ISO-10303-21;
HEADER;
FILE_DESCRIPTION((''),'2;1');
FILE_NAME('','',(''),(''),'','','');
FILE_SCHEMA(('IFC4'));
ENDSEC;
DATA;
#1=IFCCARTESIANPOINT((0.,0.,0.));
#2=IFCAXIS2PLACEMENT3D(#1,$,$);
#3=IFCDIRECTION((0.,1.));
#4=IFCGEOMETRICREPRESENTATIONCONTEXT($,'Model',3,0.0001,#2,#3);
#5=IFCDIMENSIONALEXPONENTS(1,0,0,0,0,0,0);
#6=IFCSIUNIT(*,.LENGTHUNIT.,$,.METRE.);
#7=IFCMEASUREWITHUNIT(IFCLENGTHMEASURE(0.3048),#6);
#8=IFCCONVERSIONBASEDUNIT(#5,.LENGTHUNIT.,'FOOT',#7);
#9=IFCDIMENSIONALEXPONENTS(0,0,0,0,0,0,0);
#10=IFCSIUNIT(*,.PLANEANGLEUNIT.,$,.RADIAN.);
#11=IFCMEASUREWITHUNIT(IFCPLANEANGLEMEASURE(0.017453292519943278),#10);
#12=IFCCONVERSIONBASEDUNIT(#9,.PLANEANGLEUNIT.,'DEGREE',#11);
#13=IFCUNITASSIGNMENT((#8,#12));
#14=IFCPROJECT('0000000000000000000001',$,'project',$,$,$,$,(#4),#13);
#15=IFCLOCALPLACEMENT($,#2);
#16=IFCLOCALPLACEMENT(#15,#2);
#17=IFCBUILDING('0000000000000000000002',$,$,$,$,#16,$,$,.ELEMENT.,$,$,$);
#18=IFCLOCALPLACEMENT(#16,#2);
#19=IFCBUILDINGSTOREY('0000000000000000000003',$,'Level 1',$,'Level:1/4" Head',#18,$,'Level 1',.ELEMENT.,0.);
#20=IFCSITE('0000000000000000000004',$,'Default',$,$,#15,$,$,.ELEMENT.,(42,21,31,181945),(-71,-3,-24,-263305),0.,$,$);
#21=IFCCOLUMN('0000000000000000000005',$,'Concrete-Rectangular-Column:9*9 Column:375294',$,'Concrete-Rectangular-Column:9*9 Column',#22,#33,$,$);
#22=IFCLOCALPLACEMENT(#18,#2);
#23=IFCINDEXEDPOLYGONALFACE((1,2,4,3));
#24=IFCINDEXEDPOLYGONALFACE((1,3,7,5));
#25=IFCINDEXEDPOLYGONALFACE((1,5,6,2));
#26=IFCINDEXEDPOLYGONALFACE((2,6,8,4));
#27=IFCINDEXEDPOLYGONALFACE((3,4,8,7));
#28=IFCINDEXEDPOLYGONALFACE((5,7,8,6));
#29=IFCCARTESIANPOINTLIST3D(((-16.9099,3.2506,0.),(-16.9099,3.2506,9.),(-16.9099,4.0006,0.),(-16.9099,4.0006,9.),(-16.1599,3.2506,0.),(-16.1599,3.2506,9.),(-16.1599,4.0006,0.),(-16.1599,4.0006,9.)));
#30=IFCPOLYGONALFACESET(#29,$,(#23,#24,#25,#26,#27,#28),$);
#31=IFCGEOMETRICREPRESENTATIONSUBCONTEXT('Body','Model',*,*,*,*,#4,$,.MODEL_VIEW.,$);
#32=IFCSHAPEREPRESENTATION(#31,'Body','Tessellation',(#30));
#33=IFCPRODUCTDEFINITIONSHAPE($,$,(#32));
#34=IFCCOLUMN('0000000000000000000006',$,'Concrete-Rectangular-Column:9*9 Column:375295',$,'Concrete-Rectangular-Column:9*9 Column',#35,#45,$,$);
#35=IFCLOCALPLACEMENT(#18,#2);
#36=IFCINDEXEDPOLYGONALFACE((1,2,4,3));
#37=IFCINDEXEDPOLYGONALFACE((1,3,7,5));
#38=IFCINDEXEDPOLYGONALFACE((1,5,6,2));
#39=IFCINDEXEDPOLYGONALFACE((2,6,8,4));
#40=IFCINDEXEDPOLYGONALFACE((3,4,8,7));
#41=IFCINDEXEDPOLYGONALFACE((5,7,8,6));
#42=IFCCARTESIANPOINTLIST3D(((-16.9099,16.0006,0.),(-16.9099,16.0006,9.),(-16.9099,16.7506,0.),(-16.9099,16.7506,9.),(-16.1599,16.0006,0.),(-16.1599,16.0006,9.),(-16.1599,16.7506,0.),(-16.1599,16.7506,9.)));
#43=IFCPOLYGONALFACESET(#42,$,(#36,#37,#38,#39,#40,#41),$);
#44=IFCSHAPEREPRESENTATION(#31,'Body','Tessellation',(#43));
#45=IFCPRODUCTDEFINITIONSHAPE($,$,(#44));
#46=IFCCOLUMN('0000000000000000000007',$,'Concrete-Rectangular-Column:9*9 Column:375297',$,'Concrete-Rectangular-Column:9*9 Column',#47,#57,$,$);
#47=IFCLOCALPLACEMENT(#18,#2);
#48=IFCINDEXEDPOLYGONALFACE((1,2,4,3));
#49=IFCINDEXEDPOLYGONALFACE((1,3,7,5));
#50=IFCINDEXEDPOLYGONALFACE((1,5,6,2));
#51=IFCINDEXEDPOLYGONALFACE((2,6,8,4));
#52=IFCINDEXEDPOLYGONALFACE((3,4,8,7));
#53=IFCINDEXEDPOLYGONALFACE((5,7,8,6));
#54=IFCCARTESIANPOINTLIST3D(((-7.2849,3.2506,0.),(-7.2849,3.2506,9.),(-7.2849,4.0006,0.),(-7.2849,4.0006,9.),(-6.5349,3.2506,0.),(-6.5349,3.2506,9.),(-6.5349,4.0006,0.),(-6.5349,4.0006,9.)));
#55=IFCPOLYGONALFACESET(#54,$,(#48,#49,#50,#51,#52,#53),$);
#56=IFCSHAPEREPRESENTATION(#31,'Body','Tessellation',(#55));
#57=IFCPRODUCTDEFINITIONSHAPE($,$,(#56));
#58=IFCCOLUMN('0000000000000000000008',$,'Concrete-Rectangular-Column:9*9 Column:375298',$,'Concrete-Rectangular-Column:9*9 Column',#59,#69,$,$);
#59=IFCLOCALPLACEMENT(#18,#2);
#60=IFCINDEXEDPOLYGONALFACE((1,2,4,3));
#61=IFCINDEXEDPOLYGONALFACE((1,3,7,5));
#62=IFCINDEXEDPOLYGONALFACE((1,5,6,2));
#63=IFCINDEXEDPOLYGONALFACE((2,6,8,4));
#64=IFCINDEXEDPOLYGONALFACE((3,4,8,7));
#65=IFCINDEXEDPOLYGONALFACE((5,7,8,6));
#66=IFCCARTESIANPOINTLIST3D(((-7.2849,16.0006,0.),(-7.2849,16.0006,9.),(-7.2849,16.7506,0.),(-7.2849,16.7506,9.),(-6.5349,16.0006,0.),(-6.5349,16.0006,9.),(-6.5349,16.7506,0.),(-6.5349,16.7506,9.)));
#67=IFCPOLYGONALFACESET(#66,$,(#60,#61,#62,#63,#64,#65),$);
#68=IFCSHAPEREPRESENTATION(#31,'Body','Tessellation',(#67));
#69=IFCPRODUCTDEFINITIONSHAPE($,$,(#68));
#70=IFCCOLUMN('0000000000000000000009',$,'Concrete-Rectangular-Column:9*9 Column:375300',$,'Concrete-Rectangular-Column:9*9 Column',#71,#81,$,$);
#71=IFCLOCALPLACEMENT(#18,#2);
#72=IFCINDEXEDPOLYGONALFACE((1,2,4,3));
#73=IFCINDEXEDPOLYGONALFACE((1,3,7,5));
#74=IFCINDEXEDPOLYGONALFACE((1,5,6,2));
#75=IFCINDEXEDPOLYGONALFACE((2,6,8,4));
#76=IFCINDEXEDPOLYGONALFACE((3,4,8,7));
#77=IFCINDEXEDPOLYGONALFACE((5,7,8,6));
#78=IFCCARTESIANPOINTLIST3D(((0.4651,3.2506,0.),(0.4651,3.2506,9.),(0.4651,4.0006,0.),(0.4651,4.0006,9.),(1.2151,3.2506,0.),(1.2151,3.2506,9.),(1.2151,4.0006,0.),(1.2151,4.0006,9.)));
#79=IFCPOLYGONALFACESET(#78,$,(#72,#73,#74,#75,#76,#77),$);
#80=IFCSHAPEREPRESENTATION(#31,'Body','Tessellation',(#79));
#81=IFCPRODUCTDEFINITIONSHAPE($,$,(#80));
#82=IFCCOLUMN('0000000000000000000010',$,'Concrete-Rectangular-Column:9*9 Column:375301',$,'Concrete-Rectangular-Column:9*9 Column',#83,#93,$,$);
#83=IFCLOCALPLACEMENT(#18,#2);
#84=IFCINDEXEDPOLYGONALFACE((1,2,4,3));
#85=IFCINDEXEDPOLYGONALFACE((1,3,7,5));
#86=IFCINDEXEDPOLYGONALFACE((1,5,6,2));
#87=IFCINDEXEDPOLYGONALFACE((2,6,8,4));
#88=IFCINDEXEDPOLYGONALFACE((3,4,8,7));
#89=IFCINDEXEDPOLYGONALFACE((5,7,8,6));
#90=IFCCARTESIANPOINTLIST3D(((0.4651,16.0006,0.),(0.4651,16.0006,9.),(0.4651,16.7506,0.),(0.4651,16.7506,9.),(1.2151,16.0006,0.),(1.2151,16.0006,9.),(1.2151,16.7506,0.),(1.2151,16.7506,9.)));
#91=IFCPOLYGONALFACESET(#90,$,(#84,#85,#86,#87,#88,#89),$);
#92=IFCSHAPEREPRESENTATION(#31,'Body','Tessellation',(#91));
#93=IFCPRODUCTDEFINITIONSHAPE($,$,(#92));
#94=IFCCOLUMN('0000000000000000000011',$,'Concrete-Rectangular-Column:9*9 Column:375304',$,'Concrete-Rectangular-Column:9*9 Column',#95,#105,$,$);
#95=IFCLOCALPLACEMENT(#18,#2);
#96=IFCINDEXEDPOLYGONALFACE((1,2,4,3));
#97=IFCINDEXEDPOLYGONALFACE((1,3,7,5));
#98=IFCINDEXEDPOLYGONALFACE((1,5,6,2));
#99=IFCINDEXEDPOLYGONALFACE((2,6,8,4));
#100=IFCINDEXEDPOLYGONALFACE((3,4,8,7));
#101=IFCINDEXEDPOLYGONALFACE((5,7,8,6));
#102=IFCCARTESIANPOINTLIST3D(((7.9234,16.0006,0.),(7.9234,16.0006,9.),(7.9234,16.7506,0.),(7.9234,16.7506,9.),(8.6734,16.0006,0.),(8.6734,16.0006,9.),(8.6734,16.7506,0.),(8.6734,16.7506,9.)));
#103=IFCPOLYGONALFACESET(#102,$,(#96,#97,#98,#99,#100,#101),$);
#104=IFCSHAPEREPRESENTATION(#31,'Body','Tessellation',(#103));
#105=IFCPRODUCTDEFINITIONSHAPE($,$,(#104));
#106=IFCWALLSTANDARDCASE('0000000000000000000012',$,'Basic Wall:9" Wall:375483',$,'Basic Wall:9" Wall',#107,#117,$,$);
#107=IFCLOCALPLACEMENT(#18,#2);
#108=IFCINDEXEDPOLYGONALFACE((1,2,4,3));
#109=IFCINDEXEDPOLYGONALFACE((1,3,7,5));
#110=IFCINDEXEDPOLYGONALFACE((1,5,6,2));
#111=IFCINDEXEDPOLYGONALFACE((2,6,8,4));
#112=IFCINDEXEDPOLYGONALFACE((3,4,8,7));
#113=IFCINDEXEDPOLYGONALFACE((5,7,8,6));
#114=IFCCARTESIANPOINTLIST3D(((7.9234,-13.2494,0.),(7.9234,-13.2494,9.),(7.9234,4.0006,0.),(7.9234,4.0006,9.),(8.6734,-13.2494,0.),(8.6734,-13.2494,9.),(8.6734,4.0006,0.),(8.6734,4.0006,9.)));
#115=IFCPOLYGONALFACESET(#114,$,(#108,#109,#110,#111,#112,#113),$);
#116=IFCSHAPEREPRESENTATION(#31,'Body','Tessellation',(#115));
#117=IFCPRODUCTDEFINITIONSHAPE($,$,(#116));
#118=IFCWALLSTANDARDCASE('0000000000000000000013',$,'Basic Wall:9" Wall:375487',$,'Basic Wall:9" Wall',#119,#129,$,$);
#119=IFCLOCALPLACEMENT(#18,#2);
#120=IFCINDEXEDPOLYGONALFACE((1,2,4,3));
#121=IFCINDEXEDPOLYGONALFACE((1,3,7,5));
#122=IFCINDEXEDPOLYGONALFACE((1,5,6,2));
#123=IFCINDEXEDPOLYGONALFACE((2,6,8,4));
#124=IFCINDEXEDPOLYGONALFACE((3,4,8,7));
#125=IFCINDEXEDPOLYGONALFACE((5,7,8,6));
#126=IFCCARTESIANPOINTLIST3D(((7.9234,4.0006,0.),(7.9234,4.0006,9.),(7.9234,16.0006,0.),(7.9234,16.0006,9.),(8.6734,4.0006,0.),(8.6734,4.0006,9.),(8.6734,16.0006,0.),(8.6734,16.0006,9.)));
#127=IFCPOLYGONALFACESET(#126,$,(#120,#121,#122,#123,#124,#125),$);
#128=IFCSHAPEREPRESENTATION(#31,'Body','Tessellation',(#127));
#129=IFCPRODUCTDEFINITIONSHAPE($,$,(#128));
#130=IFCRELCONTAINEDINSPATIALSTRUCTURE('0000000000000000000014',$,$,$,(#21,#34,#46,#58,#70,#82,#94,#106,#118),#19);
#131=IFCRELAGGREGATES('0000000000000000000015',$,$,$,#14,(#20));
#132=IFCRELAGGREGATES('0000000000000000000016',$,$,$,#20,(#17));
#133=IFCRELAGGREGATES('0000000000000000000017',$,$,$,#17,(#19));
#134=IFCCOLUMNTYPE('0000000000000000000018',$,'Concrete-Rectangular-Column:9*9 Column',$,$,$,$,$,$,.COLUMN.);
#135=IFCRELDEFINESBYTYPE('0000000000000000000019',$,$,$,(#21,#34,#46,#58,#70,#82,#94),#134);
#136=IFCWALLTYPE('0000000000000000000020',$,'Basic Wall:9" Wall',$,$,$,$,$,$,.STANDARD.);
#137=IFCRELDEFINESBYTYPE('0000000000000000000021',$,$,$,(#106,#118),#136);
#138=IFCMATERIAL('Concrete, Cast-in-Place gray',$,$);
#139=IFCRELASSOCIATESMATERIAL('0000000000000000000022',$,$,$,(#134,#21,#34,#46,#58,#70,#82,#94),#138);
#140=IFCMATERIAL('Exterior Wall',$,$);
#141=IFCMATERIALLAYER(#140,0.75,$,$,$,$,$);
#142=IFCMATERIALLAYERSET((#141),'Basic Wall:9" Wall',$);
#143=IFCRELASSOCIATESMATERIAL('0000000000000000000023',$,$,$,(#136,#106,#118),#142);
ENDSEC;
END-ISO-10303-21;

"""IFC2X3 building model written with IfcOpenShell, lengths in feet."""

from ifc_helpers import new_model, entity, si_unit, converted_unit, direction, frame, frame_2d, origin, origin_2d_with_axis, place, context, subcontext, project, spatial, polyline, rectangle, extrude, clip, bounded_halfspace, source, transform, mapped, material, layer, layer_set, layer_usage, type_object, type_shapes, element, save


model = new_model("IFC2X3")

# Units and contexts
model_context = context("Model", 3, precision=0.0001, world=origin(), true_north=direction((0.0, 1.0)))
body_context = subcontext(model_context, "Body", "Model", "MODEL_VIEW")
ifc_project = project(units=[converted_unit("LENGTHUNIT", "FOOT", entity("IfcLengthMeasure", 0.3048), si_unit("LENGTHUNIT", "METRE"), dimensions=[1, 0, 0, 0, 0, 0, 0]), converted_unit("PLANEANGLEUNIT", "DEGREE", entity("IfcPlaneAngleMeasure", 0.017453292519943278), si_unit("PLANEANGLEUNIT", "RADIAN"), dimensions=[0, 0, 0, 0, 0, 0, 0])], contexts=[model_context])

# Site, building, storey
site_placement = place(None, origin())
site = spatial("IfcSite", under=ifc_project, at=site_placement, Name="Default", CompositionType="ELEMENT", RefLatitude=(42, 21, 31, 181945), RefLongitude=(-71, -3, -24, -263305), RefElevation=0.0)
building_placement = place(site_placement, origin())
building = spatial("IfcBuilding", under=site, at=building_placement, CompositionType="ELEMENT")
storey_placement = place(building_placement, origin())
storey = spatial("IfcBuildingStorey", under=building, at=storey_placement, Name="Level 1", ObjectType="Level:1/4\" Head", LongName="Level 1", CompositionType="ELEMENT", Elevation=0.0)

# Columns
ifc_material_1 = material(Name="Concrete, Cast-in-Place gray")
column_type = type_object("IfcColumnType", Name="Concrete-Rectangular-Column:9*9 Column", PredefinedType="COLUMN", material=ifc_material_1)
shared_shape_1 = source(origin(), body_context, "Body", "SweptSolid", [
    extrude(rectangle(XDim=0.75, YDim=0.75, at=origin_2d_with_axis()), frame((0.0, 0.0, 0.0), z_axis=(0.0, 0.0, 1.0), x_axis=(-1.0, 0.0, 0.0)), (0.0, 0.0, 1.0), 9.0),
])
type_shapes(column_type, [shared_shape_1])
for number, where, name in (
    (1, (-16.5349, 3.6256, 0.0), "Concrete-Rectangular-Column:9*9 Column:375294"),
    (2, (-16.5349, 16.3756, 0.0), "Concrete-Rectangular-Column:9*9 Column:375295"),
    (3, (-6.9099, 3.6256, 0.0), "Concrete-Rectangular-Column:9*9 Column:375297"),
    (4, (-6.9099, 16.3756, 0.0), "Concrete-Rectangular-Column:9*9 Column:375298"),
    (5, (0.8401, 3.6256, 0.0), "Concrete-Rectangular-Column:9*9 Column:375300"),
    (6, (0.8401, 16.3756, 0.0), "Concrete-Rectangular-Column:9*9 Column:375301"),
    (7, (8.2984, 16.3756, 0.0), "Concrete-Rectangular-Column:9*9 Column:375304"),
):
    element("IfcColumn", number, at=place(storey_placement, frame(where)), inside=storey, type_object=column_type, material=ifc_material_1, Name=name, ObjectType="Concrete-Rectangular-Column:9*9 Column", context=body_context, shape_type="MappedRepresentation", body=[
        mapped(shared_shape_1, transform((0.0, 0.0, 0.0), scale=1.0)),
    ])

# Walls
ifc_material_2 = material(Name="Exterior Wall")
ifc_layer = layer(ifc_material_2, 0.75)
ifc_layer_set = layer_set([ifc_layer], Name="Basic Wall:9\" Wall")
ifc_layer_usage = layer_usage(ifc_layer_set, "AXIS2", "NEGATIVE", 0.375)
wall_type = type_object("IfcWallType", Name="Basic Wall:9\" Wall", PredefinedType="STANDARD", material=ifc_layer_set)
wall_1_placement = place(storey_placement, frame((8.2984, 4.0006, 0.0), z_axis=(0.0, 0.0, 1.0), x_axis=(0.0, -1.0, 0.0)))
element("IfcWallStandardCase", 8, at=wall_1_placement, inside=storey, type_object=wall_type, material=ifc_layer_usage, Name="Basic Wall:9\" Wall:375483", ObjectType="Basic Wall:9\" Wall", context=body_context, shape_type="Clipping", body=[
    clip(extrude(rectangle(XDim=17.25, YDim=0.75, at=frame_2d((8.625, 0.0), x_axis=(-1.0, 0.0))), origin(), (0.0, 0.0, 1.0), 9.0), bounded_halfspace(frame((0.0, -0.375, 9.0), z_axis=(0.0, 0.0, -1.0), x_axis=(1.0, 0.0, 0.0)), True, frame((0.0, -0.375, 9.0)), polyline([(0.0, 0.0), (0.75, 0.0), (13.5833, 0.0), (14.0, 0.0), (17.25, 0.0), (17.25, 0.75), (0.0, 0.75), (0.0, 0.0)]))),
])
wall_2_placement = place(storey_placement, frame((8.2984, 16.0006, 0.0), z_axis=(0.0, 0.0, 1.0), x_axis=(0.0, -1.0, 0.0)))
element("IfcWallStandardCase", 9, at=wall_2_placement, inside=storey, type_object=wall_type, material=ifc_layer_usage, Name="Basic Wall:9\" Wall:375487", ObjectType="Basic Wall:9\" Wall", context=body_context, shape_type="Clipping", body=[
    clip(extrude(rectangle(XDim=12.0, YDim=0.75, at=frame_2d((6.0, 0.0), x_axis=(-1.0, 0.0))), origin(), (0.0, 0.0, 1.0), 9.0), bounded_halfspace(frame((0.0, -0.375, 9.0), z_axis=(0.0, 0.0, -1.0), x_axis=(1.0, 0.0, 0.0)), True, frame((0.0, -0.375, 9.0)), polyline([(0.0, 0.0), (12.0, 0.0), (12.0, 0.75), (0.0, 0.75), (0.0, 0.0)]))),
])

save(model, "model.ifc")
